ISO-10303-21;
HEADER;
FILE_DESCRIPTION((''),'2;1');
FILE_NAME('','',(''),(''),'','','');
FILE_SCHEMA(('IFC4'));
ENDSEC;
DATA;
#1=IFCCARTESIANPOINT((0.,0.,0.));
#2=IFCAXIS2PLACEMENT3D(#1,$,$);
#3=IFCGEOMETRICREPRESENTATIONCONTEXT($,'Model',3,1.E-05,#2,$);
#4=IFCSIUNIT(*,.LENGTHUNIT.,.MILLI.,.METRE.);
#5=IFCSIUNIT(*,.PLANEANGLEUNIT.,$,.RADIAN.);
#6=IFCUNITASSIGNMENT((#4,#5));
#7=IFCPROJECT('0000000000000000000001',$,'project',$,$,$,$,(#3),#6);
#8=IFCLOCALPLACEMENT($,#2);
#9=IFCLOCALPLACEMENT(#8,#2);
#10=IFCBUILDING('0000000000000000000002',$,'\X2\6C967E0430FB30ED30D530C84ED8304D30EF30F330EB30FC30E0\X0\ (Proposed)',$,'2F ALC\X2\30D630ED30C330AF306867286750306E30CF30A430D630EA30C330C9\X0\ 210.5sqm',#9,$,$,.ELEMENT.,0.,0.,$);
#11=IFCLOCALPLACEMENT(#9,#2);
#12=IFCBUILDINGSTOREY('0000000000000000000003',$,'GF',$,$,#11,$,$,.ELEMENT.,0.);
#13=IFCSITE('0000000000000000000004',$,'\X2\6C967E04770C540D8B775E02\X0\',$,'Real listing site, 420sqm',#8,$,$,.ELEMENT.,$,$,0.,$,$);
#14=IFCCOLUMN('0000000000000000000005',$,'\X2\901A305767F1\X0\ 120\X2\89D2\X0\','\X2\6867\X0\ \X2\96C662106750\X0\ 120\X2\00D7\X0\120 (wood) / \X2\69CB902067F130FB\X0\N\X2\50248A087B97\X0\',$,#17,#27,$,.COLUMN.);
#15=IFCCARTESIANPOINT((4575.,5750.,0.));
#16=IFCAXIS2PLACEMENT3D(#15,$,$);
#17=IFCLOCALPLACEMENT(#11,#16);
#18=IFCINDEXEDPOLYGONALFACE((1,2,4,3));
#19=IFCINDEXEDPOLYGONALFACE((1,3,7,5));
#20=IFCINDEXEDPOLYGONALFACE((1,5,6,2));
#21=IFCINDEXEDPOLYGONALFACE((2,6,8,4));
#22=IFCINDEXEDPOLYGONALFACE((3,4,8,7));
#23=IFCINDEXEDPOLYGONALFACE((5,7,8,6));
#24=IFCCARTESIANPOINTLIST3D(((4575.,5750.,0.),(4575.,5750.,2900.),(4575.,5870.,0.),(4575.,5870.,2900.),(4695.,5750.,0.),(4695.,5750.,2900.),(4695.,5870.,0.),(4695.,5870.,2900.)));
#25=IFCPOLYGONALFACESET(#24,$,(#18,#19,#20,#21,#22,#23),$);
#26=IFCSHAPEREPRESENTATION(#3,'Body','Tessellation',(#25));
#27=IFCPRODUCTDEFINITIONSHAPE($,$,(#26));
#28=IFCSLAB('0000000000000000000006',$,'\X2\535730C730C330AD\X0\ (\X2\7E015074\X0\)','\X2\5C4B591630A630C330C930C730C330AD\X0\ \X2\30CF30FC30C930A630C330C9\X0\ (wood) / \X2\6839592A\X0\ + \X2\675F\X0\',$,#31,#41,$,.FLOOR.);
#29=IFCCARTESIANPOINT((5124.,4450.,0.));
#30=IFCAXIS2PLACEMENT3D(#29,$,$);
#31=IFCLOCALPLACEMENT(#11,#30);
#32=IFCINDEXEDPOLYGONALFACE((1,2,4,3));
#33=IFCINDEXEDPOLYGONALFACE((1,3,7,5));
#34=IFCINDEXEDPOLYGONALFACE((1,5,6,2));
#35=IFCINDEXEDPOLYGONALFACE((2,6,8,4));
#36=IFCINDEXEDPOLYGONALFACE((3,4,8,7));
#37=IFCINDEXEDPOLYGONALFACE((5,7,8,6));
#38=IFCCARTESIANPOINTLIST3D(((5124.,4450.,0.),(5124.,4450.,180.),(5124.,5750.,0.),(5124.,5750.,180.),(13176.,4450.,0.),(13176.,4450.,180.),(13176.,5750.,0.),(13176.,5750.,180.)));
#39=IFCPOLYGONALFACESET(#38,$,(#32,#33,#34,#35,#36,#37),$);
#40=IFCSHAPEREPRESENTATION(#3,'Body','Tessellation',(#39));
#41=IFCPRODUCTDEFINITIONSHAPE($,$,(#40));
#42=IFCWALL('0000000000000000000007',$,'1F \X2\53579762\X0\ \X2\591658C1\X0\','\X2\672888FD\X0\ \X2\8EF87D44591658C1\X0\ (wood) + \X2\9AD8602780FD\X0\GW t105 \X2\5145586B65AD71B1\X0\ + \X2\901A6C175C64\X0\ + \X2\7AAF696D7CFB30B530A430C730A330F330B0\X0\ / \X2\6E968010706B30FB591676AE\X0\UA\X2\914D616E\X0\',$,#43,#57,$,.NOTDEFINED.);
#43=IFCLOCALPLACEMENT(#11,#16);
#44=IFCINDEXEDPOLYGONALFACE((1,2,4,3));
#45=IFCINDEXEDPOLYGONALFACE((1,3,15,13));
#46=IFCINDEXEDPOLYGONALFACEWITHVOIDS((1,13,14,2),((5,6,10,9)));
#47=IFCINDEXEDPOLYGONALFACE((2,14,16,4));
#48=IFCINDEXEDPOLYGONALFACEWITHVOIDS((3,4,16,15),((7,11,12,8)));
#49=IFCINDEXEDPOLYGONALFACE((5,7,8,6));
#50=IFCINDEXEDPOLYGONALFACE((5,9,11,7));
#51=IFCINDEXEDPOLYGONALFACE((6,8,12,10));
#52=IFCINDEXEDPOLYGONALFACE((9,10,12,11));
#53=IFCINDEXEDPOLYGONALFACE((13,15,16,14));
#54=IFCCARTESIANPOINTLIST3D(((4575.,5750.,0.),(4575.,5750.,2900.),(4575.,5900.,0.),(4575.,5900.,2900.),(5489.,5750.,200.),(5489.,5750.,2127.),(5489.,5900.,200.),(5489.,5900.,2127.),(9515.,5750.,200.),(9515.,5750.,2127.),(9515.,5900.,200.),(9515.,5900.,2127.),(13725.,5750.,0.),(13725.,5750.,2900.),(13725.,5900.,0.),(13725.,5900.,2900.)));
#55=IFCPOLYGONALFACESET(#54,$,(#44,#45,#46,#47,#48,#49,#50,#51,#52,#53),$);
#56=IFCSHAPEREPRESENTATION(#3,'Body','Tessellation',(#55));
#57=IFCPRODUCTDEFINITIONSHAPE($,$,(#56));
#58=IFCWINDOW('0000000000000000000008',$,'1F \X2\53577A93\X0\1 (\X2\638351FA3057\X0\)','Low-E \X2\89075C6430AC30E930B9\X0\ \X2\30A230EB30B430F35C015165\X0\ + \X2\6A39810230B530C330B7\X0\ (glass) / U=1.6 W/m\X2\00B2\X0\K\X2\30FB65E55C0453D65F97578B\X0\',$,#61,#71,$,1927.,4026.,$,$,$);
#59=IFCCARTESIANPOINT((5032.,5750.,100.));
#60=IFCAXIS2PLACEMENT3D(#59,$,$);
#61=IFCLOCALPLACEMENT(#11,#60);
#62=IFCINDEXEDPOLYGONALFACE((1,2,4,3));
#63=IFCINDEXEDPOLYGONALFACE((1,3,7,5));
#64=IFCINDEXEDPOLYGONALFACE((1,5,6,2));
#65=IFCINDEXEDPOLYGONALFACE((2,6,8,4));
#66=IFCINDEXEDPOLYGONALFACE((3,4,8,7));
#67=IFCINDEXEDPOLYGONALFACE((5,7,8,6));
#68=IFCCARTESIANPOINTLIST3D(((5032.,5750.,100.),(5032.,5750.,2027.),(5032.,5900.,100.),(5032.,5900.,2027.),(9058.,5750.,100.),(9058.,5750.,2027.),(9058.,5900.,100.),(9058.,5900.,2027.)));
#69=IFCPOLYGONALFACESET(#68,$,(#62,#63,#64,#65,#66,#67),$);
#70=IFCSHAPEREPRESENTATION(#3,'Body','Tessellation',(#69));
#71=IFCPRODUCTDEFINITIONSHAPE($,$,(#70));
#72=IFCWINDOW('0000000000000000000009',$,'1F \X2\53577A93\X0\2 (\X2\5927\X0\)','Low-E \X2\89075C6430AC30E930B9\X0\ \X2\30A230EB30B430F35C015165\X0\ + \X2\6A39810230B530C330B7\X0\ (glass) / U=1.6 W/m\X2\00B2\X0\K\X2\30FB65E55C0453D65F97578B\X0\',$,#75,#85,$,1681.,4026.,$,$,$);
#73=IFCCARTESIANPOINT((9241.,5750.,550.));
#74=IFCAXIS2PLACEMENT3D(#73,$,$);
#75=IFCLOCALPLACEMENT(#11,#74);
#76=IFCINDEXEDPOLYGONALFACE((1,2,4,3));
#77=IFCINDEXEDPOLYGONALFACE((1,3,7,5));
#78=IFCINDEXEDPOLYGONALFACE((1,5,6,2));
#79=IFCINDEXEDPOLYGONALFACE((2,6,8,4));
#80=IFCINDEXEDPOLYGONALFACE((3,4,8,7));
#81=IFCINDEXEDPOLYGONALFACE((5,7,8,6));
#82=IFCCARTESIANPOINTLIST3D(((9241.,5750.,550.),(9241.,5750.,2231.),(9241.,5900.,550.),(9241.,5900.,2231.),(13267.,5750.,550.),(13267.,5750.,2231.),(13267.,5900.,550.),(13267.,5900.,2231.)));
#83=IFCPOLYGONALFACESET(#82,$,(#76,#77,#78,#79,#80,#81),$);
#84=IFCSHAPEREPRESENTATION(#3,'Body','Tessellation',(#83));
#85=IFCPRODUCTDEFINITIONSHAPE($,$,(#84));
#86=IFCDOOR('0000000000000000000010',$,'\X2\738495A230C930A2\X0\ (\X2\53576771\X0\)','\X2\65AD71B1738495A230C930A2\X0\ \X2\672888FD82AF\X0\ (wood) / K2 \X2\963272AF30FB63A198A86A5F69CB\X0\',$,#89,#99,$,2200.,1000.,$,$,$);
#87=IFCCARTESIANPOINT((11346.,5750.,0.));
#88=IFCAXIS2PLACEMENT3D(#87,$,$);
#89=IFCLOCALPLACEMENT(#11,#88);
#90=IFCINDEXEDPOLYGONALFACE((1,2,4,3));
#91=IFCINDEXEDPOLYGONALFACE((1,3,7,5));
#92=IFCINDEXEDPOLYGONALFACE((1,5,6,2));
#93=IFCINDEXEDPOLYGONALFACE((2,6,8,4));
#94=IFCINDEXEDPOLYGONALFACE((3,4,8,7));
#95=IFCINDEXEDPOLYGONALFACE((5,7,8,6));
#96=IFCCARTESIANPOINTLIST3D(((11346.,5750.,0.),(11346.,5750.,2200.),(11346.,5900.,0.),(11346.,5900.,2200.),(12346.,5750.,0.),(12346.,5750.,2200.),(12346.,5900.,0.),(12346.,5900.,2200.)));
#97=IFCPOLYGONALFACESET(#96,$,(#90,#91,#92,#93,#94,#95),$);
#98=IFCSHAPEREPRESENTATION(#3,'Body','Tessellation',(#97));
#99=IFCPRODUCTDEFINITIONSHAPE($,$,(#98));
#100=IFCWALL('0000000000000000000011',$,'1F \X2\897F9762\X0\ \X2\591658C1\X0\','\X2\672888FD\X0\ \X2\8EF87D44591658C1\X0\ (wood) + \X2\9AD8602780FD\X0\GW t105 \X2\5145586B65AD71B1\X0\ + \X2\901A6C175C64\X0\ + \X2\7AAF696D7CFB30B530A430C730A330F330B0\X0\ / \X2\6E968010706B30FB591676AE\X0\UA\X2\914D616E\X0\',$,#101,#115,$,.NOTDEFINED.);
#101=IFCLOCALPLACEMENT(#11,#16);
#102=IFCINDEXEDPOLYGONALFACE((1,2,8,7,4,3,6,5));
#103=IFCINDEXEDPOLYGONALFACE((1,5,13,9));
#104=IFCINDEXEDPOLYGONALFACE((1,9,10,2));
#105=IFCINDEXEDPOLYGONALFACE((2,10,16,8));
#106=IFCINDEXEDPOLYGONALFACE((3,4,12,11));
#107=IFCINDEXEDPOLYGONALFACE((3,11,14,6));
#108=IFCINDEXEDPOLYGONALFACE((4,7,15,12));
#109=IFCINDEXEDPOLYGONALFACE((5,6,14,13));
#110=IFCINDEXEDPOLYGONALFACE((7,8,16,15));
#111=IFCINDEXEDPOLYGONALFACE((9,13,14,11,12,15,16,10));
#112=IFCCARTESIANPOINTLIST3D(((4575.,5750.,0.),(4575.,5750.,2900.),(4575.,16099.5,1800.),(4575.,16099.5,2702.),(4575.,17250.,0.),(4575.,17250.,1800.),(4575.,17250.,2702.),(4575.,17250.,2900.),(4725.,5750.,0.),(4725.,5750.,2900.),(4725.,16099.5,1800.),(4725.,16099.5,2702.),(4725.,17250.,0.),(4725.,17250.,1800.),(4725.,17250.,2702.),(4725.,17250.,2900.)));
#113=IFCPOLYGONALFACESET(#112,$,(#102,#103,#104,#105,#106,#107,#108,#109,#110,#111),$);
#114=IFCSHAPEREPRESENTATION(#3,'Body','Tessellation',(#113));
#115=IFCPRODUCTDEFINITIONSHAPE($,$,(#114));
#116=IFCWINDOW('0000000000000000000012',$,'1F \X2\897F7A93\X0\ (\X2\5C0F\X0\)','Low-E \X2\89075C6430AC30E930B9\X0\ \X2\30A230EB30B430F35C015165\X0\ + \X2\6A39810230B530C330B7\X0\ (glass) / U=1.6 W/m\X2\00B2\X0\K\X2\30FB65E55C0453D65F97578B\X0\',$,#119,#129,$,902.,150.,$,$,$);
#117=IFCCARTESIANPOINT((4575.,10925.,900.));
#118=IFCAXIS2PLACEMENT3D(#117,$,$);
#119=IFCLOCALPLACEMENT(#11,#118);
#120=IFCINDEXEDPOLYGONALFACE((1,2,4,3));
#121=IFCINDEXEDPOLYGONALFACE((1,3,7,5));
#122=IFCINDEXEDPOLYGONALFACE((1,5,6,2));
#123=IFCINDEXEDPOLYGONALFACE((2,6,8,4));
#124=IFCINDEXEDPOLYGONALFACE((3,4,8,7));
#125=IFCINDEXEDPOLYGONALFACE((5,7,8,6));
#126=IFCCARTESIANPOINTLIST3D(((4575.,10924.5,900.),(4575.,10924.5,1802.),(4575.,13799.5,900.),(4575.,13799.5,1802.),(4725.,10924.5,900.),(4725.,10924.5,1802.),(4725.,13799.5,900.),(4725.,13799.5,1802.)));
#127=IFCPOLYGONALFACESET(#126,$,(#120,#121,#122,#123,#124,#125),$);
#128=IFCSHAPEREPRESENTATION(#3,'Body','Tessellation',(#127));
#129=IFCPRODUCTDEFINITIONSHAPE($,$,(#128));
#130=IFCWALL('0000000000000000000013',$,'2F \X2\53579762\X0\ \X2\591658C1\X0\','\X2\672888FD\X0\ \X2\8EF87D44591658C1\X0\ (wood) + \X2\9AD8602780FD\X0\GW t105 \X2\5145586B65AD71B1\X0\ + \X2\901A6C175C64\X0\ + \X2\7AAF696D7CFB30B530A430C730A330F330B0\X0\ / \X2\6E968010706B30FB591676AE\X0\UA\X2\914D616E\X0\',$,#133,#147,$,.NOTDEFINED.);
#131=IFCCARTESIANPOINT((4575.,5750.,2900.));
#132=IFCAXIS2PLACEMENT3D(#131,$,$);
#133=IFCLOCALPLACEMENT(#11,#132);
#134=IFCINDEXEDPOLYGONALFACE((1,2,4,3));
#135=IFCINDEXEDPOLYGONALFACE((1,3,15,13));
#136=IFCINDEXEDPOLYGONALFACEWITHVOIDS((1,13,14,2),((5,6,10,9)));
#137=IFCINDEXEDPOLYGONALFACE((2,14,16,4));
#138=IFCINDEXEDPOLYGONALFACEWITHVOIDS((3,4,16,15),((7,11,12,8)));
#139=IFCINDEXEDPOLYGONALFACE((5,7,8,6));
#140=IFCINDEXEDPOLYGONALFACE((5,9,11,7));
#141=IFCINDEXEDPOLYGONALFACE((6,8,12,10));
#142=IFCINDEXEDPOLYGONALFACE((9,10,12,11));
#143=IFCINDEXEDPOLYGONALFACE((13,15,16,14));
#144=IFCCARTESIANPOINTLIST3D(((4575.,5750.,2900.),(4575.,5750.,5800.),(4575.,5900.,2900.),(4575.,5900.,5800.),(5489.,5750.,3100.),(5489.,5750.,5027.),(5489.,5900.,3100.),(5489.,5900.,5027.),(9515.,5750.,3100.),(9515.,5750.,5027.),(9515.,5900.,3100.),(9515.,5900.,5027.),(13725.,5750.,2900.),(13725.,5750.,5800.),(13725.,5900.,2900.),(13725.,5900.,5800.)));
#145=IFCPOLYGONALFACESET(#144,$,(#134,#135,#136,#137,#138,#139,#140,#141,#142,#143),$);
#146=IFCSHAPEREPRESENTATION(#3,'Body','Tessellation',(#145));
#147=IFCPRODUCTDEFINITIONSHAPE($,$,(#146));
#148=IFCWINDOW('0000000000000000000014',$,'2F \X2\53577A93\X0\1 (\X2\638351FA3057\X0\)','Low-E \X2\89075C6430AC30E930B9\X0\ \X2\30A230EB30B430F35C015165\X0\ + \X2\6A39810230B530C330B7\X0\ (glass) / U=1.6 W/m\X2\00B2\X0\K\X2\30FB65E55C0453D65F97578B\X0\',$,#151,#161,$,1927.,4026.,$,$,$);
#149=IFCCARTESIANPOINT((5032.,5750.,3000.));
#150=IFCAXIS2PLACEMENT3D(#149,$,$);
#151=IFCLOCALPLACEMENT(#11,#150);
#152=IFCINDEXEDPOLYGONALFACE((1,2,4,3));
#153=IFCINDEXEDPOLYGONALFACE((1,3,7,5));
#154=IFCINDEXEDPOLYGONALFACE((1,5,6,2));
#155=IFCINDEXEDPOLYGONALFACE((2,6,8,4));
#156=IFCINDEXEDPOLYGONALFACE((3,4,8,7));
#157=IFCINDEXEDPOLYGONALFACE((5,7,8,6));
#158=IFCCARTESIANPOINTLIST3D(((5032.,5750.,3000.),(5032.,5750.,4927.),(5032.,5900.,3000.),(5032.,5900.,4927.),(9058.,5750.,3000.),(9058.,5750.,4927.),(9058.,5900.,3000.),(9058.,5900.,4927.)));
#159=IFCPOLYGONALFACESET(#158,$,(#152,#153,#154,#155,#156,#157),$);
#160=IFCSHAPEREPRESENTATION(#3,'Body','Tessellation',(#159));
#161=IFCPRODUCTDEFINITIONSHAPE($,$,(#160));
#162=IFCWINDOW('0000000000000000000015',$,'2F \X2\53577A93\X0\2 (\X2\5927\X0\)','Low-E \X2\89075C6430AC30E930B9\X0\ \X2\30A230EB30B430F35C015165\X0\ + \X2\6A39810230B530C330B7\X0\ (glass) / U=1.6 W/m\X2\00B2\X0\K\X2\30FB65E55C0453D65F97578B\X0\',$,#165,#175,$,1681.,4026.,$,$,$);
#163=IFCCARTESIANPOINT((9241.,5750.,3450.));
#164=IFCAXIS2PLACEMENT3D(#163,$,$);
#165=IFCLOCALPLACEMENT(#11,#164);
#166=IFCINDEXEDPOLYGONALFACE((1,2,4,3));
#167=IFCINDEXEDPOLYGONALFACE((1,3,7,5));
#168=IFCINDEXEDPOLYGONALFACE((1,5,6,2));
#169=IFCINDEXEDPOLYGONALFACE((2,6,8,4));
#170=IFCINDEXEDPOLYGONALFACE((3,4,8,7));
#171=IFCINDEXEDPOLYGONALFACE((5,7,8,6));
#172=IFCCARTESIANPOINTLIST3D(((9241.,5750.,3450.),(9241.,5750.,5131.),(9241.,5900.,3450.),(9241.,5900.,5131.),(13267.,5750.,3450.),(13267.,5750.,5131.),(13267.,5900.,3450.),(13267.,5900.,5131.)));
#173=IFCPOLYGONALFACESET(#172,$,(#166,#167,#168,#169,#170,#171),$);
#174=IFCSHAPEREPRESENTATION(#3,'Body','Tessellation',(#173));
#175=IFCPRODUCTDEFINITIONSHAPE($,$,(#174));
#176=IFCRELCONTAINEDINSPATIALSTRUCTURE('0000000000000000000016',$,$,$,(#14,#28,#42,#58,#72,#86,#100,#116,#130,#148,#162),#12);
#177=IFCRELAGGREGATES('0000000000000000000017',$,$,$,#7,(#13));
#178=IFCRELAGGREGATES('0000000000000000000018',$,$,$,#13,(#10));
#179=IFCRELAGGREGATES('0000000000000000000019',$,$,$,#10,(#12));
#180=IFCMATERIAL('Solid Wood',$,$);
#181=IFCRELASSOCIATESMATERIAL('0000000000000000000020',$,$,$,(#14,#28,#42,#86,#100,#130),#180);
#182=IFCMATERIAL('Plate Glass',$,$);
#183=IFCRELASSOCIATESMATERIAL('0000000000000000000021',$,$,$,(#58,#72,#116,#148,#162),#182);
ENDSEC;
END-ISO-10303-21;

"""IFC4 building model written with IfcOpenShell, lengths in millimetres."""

from ifc_helpers import new_model, si_unit, frame, frame_2d, origin, place, context, project, spatial, rectangle, extrude, material, element, fill, save


model = new_model("IFC4")

# Units and contexts
model_context = context("Model", 3, precision=1e-05, world=origin())
ifc_project = project(units=[si_unit("LENGTHUNIT", "METRE", prefix="MILLI"), si_unit("PLANEANGLEUNIT", "RADIAN")], contexts=[model_context])

# Site, building, storey
site_placement = place(None, origin())
site = spatial("IfcSite", under=ifc_project, at=site_placement, Name="沖縄県名護市", ObjectType="Real listing site, 420sqm", CompositionType="ELEMENT", RefElevation=0.0)
building_placement = place(site_placement, origin())
building = spatial("IfcBuilding", under=site, at=building_placement, Name="沖縄・ロフト付きワンルーム (Proposed)", ObjectType="2F ALCブロックと木材のハイブリッド 210.5sqm", CompositionType="ELEMENT", ElevationOfRefHeight=0.0, ElevationOfTerrain=0.0)
storey_placement = place(building_placement, origin())
storey = spatial("IfcBuildingStorey", under=building, at=storey_placement, Name="GF", CompositionType="ELEMENT", Elevation=0.0)

# Column
ifc_material_1 = material(Name="Solid Wood")
column_placement = place(storey_placement, frame((4575.0, 5750.0, 0.0)))
element("IfcColumn", 1, at=column_placement, inside=storey, material=ifc_material_1, Name="通し柱 120角", Description="桧 集成材 120×120 (wood) / 構造柱・N値計算", PredefinedType="COLUMN", context=model_context, shape_type="SweptSolid", body=[
    extrude(rectangle(XDim=120.0, YDim=120.0, at=frame_2d((60.0, 60.0))), frame((4575.0, 5750.0, 0.0)), (0.0, 0.0, 1.0), 2900.0),
])

# Slab
slab_1_placement = place(storey_placement, frame((5124.0, 4450.0, 0.0)))
element("IfcSlab", 2, at=slab_1_placement, inside=storey, material=ifc_material_1, Name="南デッキ (縁側)", Description="屋外ウッドデッキ ハードウッド (wood) / 根太 + 束", PredefinedType="FLOOR", context=model_context, shape_type="SweptSolid", body=[
    extrude(rectangle(XDim=8052.0, YDim=1300.0, at=frame_2d((4026.0, 650.0))), frame((5124.0, 4450.0, 0.0)), (0.0, 0.0, 1.0), 180.0),
])

# Wall, openings, windows, door
wall_1_placement = place(storey_placement, frame((4575.0, 5750.0, 0.0)))
wall_1 = element("IfcWall", 3, at=wall_1_placement, inside=storey, material=ifc_material_1, Name="1F 南面 外壁", Description="木製 軸組外壁 (wood) + 高性能GW t105 充填断熱 + 通気層 + 窯業系サイディング / 準耐火・外皮UA配慮", PredefinedType="NOTDEFINED", context=model_context, shape_type="SweptSolid", body=[
    extrude(rectangle(XDim=9150.0, YDim=150.0, at=frame_2d((4575.0, 75.0))), frame((4575.0, 5750.0, 0.0)), (0.0, 0.0, 1.0), 2900.0),
])
opening_1_placement = place(storey_placement, frame((5032.0, 5750.0, 100.0)))
opening_1 = element("IfcOpeningElement", 4, at=opening_1_placement, cuts=wall_1, PredefinedType="NOTDEFINED", context=model_context, shape_type="SweptSolid", body=[
    extrude(rectangle(XDim=4026.0, YDim=150.0, at=frame_2d((2013.0, 75.0))), frame((5032.0, 5750.0, 100.0)), (0.0, 0.0, 1.0), 1927.0),
])
opening_2_placement = place(storey_placement, frame((9241.0, 5750.0, 550.0)))
opening_2 = element("IfcOpeningElement", 5, at=opening_2_placement, cuts=wall_1, PredefinedType="NOTDEFINED", context=model_context, shape_type="SweptSolid", body=[
    extrude(rectangle(XDim=4026.0, YDim=150.0, at=frame_2d((2013.0, 75.0))), frame((9241.0, 5750.0, 550.0)), (0.0, 0.0, 1.0), 1681.0),
])
opening_3_placement = place(storey_placement, frame((11346.0, 5750.0, 0.0)))
opening_3 = element("IfcOpeningElement", 6, at=opening_3_placement, cuts=wall_1, PredefinedType="NOTDEFINED", context=model_context, shape_type="SweptSolid", body=[
    extrude(rectangle(XDim=1000.0, YDim=150.0, at=frame_2d((500.0, 75.0))), frame((11346.0, 5750.0, 0.0)), (0.0, 0.0, 1.0), 2200.0),
])
ifc_material_2 = material(Name="Plate Glass")
window_1_placement = place(storey_placement, frame((5032.0, 5750.0, 100.0)))
window_1 = element("IfcWindow", 7, at=window_1_placement, inside=storey, material=ifc_material_2, Name="1F 南窓1 (掃出し)", Description="Low-E 複層ガラス アルゴン封入 + 樹脂サッシ (glass) / U=1.6 W/m²K・日射取得型", OverallHeight=1927.0, OverallWidth=4026.0, context=model_context, shape_type="SweptSolid", body=[
    extrude(rectangle(XDim=4026.0, YDim=150.0, at=frame_2d((2013.0, 75.0))), frame((5032.0, 5750.0, 100.0)), (0.0, 0.0, 1.0), 1927.0),
])
fill(opening_1, window_1)
window_2_placement = place(storey_placement, frame((9241.0, 5750.0, 550.0)))
window_2 = element("IfcWindow", 8, at=window_2_placement, inside=storey, material=ifc_material_2, Name="1F 南窓2 (大)", Description="Low-E 複層ガラス アルゴン封入 + 樹脂サッシ (glass) / U=1.6 W/m²K・日射取得型", OverallHeight=1681.0, OverallWidth=4026.0, context=model_context, shape_type="SweptSolid", body=[
    extrude(rectangle(XDim=4026.0, YDim=150.0, at=frame_2d((2013.0, 75.0))), frame((9241.0, 5750.0, 550.0)), (0.0, 0.0, 1.0), 1681.0),
])
fill(opening_2, window_2)
door_placement = place(storey_placement, frame((11346.0, 5750.0, 0.0)))
door = element("IfcDoor", 9, at=door_placement, inside=storey, material=ifc_material_1, Name="玄関ドア (南東)", Description="断熱玄関ドア 木製芯 (wood) / K2 防犯・採風機構", OverallHeight=2200.0, OverallWidth=1000.0, context=model_context, shape_type="SweptSolid", body=[
    extrude(rectangle(XDim=1000.0, YDim=150.0, at=frame_2d((500.0, 75.0))), frame((11346.0, 5750.0, 0.0)), (0.0, 0.0, 1.0), 2200.0),
])
fill(opening_3, door)

# Wall, opening, window
wall_2_placement = place(storey_placement, frame((4575.0, 5750.0, 0.0)))
wall_2 = element("IfcWall", 10, at=wall_2_placement, inside=storey, material=ifc_material_1, Name="1F 西面 外壁", Description="木製 軸組外壁 (wood) + 高性能GW t105 充填断熱 + 通気層 + 窯業系サイディング / 準耐火・外皮UA配慮", PredefinedType="NOTDEFINED", context=model_context, shape_type="SweptSolid", body=[
    extrude(rectangle(XDim=150.0, YDim=11500.0, at=frame_2d((75.0, 5750.0))), frame((4575.0, 5750.0, 0.0)), (0.0, 0.0, 1.0), 2900.0),
])
opening_4_placement = place(storey_placement, frame((4575.0, 10925.0, 900.0)))
opening_4 = element("IfcOpeningElement", 11, at=opening_4_placement, cuts=wall_2, PredefinedType="NOTDEFINED", context=model_context, shape_type="SweptSolid", body=[
    extrude(rectangle(XDim=150.0, YDim=2875.0, at=frame_2d((75.0, 1437.0))), frame((4575.0, 10925.0, 900.0)), (0.0, 0.0, 1.0), 902.0),
])
window_3_placement = place(storey_placement, frame((4575.0, 10925.0, 900.0)))
window_3 = element("IfcWindow", 12, at=window_3_placement, inside=storey, material=ifc_material_2, Name="1F 西窓 (小)", Description="Low-E 複層ガラス アルゴン封入 + 樹脂サッシ (glass) / U=1.6 W/m²K・日射取得型", OverallHeight=902.0, OverallWidth=150.0, context=model_context, shape_type="SweptSolid", body=[
    extrude(rectangle(XDim=150.0, YDim=2875.0, at=frame_2d((75.0, 1437.0))), frame((4575.0, 10925.0, 900.0)), (0.0, 0.0, 1.0), 902.0),
])
fill(opening_4, window_3)

# Wall, openings, windows
wall_3_placement = place(storey_placement, frame((4575.0, 5750.0, 2900.0)))
wall_3 = element("IfcWall", 13, at=wall_3_placement, inside=storey, material=ifc_material_1, Name="2F 南面 外壁", Description="木製 軸組外壁 (wood) + 高性能GW t105 充填断熱 + 通気層 + 窯業系サイディング / 準耐火・外皮UA配慮", PredefinedType="NOTDEFINED", context=model_context, shape_type="SweptSolid", body=[
    extrude(rectangle(XDim=9150.0, YDim=150.0, at=frame_2d((4575.0, 75.0))), frame((4575.0, 5750.0, 2900.0)), (0.0, 0.0, 1.0), 2900.0),
])
opening_5_placement = place(storey_placement, frame((5032.0, 5750.0, 3000.0)))
opening_5 = element("IfcOpeningElement", 14, at=opening_5_placement, cuts=wall_3, PredefinedType="NOTDEFINED", context=model_context, shape_type="SweptSolid", body=[
    extrude(rectangle(XDim=4026.0, YDim=150.0, at=frame_2d((2013.0, 75.0))), frame((5032.0, 5750.0, 3000.0)), (0.0, 0.0, 1.0), 1927.0),
])
opening_6_placement = place(storey_placement, frame((9241.0, 5750.0, 3450.0)))
opening_6 = element("IfcOpeningElement", 15, at=opening_6_placement, cuts=wall_3, PredefinedType="NOTDEFINED", context=model_context, shape_type="SweptSolid", body=[
    extrude(rectangle(XDim=4026.0, YDim=150.0, at=frame_2d((2013.0, 75.0))), frame((9241.0, 5750.0, 3450.0)), (0.0, 0.0, 1.0), 1681.0),
])
window_4_placement = place(storey_placement, frame((5032.0, 5750.0, 3000.0)))
window_4 = element("IfcWindow", 16, at=window_4_placement, inside=storey, material=ifc_material_2, Name="2F 南窓1 (掃出し)", Description="Low-E 複層ガラス アルゴン封入 + 樹脂サッシ (glass) / U=1.6 W/m²K・日射取得型", OverallHeight=1927.0, OverallWidth=4026.0, context=model_context, shape_type="SweptSolid", body=[
    extrude(rectangle(XDim=4026.0, YDim=150.0, at=frame_2d((2013.0, 75.0))), frame((5032.0, 5750.0, 3000.0)), (0.0, 0.0, 1.0), 1927.0),
])
fill(opening_5, window_4)
window_5_placement = place(storey_placement, frame((9241.0, 5750.0, 3450.0)))
window_5 = element("IfcWindow", 17, at=window_5_placement, inside=storey, material=ifc_material_2, Name="2F 南窓2 (大)", Description="Low-E 複層ガラス アルゴン封入 + 樹脂サッシ (glass) / U=1.6 W/m²K・日射取得型", OverallHeight=1681.0, OverallWidth=4026.0, context=model_context, shape_type="SweptSolid", body=[
    extrude(rectangle(XDim=4026.0, YDim=150.0, at=frame_2d((2013.0, 75.0))), frame((9241.0, 5750.0, 3450.0)), (0.0, 0.0, 1.0), 1681.0),
])
fill(opening_6, window_5)

save(model, "model.ifc")
